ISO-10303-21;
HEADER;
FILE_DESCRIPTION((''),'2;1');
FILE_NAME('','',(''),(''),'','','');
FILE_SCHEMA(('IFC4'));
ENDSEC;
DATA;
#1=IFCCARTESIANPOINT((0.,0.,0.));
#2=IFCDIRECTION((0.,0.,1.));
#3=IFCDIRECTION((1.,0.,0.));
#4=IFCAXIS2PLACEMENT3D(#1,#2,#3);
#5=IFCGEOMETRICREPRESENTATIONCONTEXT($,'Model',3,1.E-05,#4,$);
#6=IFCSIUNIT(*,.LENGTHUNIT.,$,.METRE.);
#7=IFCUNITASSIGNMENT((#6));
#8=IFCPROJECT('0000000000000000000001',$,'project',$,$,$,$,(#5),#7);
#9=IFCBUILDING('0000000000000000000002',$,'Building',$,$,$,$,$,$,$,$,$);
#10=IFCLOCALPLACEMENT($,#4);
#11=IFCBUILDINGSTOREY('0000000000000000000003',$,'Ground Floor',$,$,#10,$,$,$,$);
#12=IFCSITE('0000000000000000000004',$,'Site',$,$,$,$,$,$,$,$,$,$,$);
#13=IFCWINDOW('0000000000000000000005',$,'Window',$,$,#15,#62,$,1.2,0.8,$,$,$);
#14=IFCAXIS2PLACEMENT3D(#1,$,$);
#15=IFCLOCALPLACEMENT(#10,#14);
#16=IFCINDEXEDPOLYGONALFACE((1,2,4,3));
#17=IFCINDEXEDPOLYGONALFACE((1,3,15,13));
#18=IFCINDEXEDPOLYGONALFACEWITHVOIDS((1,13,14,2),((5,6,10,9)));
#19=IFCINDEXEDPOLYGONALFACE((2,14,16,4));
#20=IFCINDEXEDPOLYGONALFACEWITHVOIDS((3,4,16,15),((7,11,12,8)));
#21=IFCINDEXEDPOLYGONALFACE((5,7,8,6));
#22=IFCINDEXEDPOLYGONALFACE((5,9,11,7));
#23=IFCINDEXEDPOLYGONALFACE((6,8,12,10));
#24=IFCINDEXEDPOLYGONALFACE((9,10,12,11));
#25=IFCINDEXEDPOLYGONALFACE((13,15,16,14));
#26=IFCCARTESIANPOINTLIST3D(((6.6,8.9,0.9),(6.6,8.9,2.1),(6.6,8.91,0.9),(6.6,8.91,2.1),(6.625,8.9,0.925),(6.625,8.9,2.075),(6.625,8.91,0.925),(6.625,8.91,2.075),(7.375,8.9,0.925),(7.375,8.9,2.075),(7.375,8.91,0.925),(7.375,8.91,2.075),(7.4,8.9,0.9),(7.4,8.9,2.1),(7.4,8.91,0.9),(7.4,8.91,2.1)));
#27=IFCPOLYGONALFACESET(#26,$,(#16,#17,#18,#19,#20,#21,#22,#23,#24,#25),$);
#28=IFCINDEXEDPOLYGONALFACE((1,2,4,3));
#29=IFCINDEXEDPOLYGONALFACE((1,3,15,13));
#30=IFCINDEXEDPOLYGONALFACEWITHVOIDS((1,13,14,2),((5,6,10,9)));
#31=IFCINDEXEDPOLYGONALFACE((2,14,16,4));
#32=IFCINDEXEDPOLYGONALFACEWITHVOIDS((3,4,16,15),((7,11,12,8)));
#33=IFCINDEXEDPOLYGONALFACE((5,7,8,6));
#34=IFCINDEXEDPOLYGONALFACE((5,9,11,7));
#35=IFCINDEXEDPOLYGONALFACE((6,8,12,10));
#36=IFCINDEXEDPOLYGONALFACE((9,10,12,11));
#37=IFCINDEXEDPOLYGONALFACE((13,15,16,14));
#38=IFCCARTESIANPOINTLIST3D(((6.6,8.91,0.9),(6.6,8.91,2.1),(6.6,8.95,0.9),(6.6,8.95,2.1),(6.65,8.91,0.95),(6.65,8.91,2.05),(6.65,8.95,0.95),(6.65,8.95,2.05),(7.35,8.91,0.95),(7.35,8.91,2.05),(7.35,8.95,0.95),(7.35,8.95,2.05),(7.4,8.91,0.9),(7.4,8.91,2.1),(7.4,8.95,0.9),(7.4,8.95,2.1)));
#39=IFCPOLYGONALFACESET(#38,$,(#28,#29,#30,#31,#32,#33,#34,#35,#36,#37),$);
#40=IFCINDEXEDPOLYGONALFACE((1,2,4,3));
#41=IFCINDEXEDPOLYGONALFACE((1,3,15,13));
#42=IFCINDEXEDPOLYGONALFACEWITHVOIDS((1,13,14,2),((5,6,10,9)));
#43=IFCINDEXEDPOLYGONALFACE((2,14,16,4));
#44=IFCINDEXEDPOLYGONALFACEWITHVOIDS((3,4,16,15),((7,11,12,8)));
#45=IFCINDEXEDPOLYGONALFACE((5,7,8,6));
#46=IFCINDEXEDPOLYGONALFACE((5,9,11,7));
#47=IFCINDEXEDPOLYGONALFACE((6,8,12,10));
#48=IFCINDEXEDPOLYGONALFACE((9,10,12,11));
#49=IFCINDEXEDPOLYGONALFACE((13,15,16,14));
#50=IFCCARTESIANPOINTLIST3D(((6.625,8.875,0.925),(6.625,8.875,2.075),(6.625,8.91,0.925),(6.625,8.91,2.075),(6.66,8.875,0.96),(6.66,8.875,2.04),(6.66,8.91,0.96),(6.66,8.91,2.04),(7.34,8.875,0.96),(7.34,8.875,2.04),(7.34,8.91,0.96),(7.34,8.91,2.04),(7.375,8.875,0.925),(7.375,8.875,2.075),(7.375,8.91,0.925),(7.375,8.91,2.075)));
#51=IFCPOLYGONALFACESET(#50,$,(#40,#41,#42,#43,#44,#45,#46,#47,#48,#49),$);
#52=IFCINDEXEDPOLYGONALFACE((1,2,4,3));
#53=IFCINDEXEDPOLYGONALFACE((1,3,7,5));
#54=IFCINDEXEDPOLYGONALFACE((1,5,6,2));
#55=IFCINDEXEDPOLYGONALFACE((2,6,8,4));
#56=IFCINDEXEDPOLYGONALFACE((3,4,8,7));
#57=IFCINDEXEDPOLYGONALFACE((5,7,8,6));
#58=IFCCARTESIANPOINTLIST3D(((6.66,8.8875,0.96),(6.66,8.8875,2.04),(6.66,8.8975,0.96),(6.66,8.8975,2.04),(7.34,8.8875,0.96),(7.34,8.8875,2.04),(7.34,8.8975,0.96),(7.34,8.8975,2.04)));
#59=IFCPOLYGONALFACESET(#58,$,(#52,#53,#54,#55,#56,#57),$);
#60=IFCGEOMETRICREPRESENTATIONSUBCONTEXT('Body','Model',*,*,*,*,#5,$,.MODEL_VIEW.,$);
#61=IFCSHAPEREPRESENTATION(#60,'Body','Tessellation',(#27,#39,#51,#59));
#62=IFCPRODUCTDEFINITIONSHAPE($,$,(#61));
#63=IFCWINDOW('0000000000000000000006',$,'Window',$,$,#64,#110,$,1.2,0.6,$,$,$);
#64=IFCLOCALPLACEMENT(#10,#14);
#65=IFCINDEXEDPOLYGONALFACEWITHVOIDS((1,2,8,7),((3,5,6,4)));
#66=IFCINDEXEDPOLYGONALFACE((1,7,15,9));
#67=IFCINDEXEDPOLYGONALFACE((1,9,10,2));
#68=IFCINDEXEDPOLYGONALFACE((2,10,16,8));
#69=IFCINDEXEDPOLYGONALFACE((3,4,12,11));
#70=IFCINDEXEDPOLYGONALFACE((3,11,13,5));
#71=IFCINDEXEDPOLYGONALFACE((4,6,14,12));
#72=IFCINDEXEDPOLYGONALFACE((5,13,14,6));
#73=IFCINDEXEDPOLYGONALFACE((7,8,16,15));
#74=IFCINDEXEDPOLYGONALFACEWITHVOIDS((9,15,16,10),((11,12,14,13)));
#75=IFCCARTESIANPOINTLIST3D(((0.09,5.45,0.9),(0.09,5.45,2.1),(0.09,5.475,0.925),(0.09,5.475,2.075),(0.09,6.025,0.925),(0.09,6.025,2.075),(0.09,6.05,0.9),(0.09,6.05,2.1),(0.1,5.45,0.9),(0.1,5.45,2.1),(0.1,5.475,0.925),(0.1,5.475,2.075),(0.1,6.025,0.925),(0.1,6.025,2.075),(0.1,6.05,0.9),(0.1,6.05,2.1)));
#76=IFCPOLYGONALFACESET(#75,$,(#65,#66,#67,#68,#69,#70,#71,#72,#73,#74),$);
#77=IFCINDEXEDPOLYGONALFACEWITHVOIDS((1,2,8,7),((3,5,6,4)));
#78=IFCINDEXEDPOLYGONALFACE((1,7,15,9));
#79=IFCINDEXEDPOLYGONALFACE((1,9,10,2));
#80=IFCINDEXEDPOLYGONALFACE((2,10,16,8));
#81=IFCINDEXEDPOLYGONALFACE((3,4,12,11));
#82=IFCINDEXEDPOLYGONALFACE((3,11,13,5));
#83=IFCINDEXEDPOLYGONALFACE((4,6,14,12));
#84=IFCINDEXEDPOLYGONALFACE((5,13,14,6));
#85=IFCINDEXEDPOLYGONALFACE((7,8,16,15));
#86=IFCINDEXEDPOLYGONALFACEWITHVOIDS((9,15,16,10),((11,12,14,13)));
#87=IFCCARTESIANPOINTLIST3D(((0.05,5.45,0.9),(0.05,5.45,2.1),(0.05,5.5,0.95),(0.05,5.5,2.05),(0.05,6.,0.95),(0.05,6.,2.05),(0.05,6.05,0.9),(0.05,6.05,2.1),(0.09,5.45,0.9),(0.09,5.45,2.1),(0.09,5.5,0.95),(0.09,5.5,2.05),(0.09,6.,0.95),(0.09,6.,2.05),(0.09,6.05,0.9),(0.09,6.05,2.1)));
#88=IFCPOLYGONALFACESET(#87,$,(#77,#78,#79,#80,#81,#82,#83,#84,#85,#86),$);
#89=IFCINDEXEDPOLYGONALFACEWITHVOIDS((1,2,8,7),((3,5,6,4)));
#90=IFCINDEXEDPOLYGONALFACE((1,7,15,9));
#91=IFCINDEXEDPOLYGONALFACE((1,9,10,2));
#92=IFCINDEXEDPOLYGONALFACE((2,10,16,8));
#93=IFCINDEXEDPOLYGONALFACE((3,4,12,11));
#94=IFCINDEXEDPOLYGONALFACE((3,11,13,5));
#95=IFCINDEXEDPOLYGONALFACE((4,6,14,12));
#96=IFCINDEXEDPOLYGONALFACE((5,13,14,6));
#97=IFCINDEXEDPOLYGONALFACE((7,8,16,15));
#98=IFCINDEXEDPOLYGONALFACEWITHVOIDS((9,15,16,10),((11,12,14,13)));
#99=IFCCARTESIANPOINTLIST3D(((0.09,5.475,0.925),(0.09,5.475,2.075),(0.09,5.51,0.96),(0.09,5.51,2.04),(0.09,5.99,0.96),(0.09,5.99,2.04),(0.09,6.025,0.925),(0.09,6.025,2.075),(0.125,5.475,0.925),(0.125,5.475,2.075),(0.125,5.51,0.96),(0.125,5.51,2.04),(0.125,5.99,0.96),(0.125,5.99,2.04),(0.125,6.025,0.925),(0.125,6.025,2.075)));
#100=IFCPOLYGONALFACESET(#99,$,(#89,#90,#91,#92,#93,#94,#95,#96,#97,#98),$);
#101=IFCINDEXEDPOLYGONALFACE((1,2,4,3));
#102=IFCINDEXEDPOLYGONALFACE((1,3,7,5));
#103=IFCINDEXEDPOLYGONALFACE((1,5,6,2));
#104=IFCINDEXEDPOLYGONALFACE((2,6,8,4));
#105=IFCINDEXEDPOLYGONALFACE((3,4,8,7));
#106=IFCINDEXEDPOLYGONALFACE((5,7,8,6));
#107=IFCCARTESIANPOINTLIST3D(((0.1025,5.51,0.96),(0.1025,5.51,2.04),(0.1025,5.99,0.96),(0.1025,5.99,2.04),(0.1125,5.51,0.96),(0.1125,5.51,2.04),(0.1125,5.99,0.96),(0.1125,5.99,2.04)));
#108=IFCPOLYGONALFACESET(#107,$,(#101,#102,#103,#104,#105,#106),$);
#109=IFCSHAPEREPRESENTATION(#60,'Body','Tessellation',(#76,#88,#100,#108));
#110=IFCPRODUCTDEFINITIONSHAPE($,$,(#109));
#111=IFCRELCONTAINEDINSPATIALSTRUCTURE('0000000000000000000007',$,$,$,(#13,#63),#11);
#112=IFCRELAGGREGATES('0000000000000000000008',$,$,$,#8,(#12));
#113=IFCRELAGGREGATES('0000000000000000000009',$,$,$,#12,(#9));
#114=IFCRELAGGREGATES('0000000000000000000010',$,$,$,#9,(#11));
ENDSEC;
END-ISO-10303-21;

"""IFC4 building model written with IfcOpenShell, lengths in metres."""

from ifc_helpers import new_model, si_unit, frame, origin_with_axes, place, context, subcontext, project, spatial, line, indexed_curve, outline, extrude, element, save


model = new_model("IFC4")

# Units and contexts
model_context = context("Model", 3, precision=1e-05, world=origin_with_axes())
body_context = subcontext(model_context, "Body", "Model", "MODEL_VIEW")
ifc_project = project(units=[si_unit("LENGTHUNIT", "METRE")], contexts=[model_context])

# Site, building, storey
site = spatial("IfcSite", under=ifc_project, Name="Site")
building = spatial("IfcBuilding", under=site, Name="Building")
storey_placement = place(None, origin_with_axes())
storey = spatial("IfcBuildingStorey", under=building, at=storey_placement, Name="Ground Floor")

# Windows
window_1_placement = place(storey_placement, frame((7.4, 9.0, 0.9), z_axis=(0.0, 0.0, 1.0), x_axis=(-1.0, 0.0, 0.0)))
element("IfcWindow", 1, at=window_1_placement, inside=storey, Name="Window", OverallHeight=1.2, OverallWidth=0.8, context=body_context, shape_type="SweptSolid", body=[
    extrude(outline(indexed_curve([(0.0, 0.0), (0.8, 0.0), (0.8, 1.2), (0.0, 1.2)], segments=[line(1, 2, 3, 4, 1)]), holes=[indexed_curve([(0.025, 0.025), (0.775, 0.025), (0.775, 1.175), (0.025, 1.175)], segments=[line(1, 2, 3, 4, 1)])]), frame((0.0, 0.09, 0.0), z_axis=(0.0, -1.0, 0.0), x_axis=(1.0, 0.0, 0.0)), (0.0, 0.0, -1.0), 0.01),
    extrude(outline(indexed_curve([(0.0, 0.0), (0.8, 0.0), (0.8, 1.2), (0.0, 1.2)], segments=[line(1, 2, 3, 4, 1)]), holes=[indexed_curve([(0.05, 0.05), (0.75, 0.05), (0.75, 1.15), (0.05, 1.15)], segments=[line(1, 2, 3, 4, 1)])]), frame((0.0, 0.05, 0.0), z_axis=(0.0, -1.0, 0.0), x_axis=(1.0, 0.0, 0.0)), (0.0, 0.0, -1.0), 0.04),
    extrude(outline(indexed_curve([(0.0, 0.0), (0.75, 0.0), (0.75, 1.15), (0.0, 1.15)], segments=[line(1, 2, 3, 4, 1)]), holes=[indexed_curve([(0.035, 0.035), (0.715, 0.035), (0.715, 1.115), (0.035, 1.115)], segments=[line(1, 2, 3, 4, 1)])]), frame((0.025, 0.09, 0.025), z_axis=(0.0, -1.0, 0.0), x_axis=(1.0, 0.0, 0.0)), (0.0, 0.0, -1.0), 0.035),
    extrude(outline(indexed_curve([(0.035, 0.035), (0.715, 0.035), (0.715, 1.115), (0.035, 1.115)], segments=[line(1, 2, 3, 4, 1)])), frame((0.025, 0.1025, 0.025), z_axis=(0.0, -1.0, 0.0), x_axis=(1.0, 0.0, 0.0)), (0.0, 0.0, -1.0), 0.01),
])
window_2_placement = place(storey_placement, frame((0.0, 6.05, 0.9), z_axis=(0.0, 0.0, 1.0), x_axis=(0.0, -1.0, 0.0)))
element("IfcWindow", 2, at=window_2_placement, inside=storey, Name="Window", OverallHeight=1.2, OverallWidth=0.6, context=body_context, shape_type="SweptSolid", body=[
    extrude(outline(indexed_curve([(0.0, 0.0), (0.6, 0.0), (0.6, 1.2), (0.0, 1.2)], segments=[line(1, 2, 3, 4, 1)]), holes=[indexed_curve([(0.025, 0.025), (0.575, 0.025), (0.575, 1.175), (0.025, 1.175)], segments=[line(1, 2, 3, 4, 1)])]), frame((0.0, 0.09, 0.0), z_axis=(0.0, -1.0, 0.0), x_axis=(1.0, 0.0, 0.0)), (0.0, 0.0, -1.0), 0.01),
    extrude(outline(indexed_curve([(0.0, 0.0), (0.6, 0.0), (0.6, 1.2), (0.0, 1.2)], segments=[line(1, 2, 3, 4, 1)]), holes=[indexed_curve([(0.05, 0.05), (0.55, 0.05), (0.55, 1.15), (0.05, 1.15)], segments=[line(1, 2, 3, 4, 1)])]), frame((0.0, 0.05, 0.0), z_axis=(0.0, -1.0, 0.0), x_axis=(1.0, 0.0, 0.0)), (0.0, 0.0, -1.0), 0.04),
    extrude(outline(indexed_curve([(0.0, 0.0), (0.55, 0.0), (0.55, 1.15), (0.0, 1.15)], segments=[line(1, 2, 3, 4, 1)]), holes=[indexed_curve([(0.035, 0.035), (0.515, 0.035), (0.515, 1.115), (0.035, 1.115)], segments=[line(1, 2, 3, 4, 1)])]), frame((0.025, 0.09, 0.025), z_axis=(0.0, -1.0, 0.0), x_axis=(1.0, 0.0, 0.0)), (0.0, 0.0, -1.0), 0.035),
    extrude(outline(indexed_curve([(0.035, 0.035), (0.515, 0.035), (0.515, 1.115), (0.035, 1.115)], segments=[line(1, 2, 3, 4, 1)])), frame((0.025, 0.1025, 0.025), z_axis=(0.0, -1.0, 0.0), x_axis=(1.0, 0.0, 0.0)), (0.0, 0.0, -1.0), 0.01),
])

save(model, "model.ifc")
